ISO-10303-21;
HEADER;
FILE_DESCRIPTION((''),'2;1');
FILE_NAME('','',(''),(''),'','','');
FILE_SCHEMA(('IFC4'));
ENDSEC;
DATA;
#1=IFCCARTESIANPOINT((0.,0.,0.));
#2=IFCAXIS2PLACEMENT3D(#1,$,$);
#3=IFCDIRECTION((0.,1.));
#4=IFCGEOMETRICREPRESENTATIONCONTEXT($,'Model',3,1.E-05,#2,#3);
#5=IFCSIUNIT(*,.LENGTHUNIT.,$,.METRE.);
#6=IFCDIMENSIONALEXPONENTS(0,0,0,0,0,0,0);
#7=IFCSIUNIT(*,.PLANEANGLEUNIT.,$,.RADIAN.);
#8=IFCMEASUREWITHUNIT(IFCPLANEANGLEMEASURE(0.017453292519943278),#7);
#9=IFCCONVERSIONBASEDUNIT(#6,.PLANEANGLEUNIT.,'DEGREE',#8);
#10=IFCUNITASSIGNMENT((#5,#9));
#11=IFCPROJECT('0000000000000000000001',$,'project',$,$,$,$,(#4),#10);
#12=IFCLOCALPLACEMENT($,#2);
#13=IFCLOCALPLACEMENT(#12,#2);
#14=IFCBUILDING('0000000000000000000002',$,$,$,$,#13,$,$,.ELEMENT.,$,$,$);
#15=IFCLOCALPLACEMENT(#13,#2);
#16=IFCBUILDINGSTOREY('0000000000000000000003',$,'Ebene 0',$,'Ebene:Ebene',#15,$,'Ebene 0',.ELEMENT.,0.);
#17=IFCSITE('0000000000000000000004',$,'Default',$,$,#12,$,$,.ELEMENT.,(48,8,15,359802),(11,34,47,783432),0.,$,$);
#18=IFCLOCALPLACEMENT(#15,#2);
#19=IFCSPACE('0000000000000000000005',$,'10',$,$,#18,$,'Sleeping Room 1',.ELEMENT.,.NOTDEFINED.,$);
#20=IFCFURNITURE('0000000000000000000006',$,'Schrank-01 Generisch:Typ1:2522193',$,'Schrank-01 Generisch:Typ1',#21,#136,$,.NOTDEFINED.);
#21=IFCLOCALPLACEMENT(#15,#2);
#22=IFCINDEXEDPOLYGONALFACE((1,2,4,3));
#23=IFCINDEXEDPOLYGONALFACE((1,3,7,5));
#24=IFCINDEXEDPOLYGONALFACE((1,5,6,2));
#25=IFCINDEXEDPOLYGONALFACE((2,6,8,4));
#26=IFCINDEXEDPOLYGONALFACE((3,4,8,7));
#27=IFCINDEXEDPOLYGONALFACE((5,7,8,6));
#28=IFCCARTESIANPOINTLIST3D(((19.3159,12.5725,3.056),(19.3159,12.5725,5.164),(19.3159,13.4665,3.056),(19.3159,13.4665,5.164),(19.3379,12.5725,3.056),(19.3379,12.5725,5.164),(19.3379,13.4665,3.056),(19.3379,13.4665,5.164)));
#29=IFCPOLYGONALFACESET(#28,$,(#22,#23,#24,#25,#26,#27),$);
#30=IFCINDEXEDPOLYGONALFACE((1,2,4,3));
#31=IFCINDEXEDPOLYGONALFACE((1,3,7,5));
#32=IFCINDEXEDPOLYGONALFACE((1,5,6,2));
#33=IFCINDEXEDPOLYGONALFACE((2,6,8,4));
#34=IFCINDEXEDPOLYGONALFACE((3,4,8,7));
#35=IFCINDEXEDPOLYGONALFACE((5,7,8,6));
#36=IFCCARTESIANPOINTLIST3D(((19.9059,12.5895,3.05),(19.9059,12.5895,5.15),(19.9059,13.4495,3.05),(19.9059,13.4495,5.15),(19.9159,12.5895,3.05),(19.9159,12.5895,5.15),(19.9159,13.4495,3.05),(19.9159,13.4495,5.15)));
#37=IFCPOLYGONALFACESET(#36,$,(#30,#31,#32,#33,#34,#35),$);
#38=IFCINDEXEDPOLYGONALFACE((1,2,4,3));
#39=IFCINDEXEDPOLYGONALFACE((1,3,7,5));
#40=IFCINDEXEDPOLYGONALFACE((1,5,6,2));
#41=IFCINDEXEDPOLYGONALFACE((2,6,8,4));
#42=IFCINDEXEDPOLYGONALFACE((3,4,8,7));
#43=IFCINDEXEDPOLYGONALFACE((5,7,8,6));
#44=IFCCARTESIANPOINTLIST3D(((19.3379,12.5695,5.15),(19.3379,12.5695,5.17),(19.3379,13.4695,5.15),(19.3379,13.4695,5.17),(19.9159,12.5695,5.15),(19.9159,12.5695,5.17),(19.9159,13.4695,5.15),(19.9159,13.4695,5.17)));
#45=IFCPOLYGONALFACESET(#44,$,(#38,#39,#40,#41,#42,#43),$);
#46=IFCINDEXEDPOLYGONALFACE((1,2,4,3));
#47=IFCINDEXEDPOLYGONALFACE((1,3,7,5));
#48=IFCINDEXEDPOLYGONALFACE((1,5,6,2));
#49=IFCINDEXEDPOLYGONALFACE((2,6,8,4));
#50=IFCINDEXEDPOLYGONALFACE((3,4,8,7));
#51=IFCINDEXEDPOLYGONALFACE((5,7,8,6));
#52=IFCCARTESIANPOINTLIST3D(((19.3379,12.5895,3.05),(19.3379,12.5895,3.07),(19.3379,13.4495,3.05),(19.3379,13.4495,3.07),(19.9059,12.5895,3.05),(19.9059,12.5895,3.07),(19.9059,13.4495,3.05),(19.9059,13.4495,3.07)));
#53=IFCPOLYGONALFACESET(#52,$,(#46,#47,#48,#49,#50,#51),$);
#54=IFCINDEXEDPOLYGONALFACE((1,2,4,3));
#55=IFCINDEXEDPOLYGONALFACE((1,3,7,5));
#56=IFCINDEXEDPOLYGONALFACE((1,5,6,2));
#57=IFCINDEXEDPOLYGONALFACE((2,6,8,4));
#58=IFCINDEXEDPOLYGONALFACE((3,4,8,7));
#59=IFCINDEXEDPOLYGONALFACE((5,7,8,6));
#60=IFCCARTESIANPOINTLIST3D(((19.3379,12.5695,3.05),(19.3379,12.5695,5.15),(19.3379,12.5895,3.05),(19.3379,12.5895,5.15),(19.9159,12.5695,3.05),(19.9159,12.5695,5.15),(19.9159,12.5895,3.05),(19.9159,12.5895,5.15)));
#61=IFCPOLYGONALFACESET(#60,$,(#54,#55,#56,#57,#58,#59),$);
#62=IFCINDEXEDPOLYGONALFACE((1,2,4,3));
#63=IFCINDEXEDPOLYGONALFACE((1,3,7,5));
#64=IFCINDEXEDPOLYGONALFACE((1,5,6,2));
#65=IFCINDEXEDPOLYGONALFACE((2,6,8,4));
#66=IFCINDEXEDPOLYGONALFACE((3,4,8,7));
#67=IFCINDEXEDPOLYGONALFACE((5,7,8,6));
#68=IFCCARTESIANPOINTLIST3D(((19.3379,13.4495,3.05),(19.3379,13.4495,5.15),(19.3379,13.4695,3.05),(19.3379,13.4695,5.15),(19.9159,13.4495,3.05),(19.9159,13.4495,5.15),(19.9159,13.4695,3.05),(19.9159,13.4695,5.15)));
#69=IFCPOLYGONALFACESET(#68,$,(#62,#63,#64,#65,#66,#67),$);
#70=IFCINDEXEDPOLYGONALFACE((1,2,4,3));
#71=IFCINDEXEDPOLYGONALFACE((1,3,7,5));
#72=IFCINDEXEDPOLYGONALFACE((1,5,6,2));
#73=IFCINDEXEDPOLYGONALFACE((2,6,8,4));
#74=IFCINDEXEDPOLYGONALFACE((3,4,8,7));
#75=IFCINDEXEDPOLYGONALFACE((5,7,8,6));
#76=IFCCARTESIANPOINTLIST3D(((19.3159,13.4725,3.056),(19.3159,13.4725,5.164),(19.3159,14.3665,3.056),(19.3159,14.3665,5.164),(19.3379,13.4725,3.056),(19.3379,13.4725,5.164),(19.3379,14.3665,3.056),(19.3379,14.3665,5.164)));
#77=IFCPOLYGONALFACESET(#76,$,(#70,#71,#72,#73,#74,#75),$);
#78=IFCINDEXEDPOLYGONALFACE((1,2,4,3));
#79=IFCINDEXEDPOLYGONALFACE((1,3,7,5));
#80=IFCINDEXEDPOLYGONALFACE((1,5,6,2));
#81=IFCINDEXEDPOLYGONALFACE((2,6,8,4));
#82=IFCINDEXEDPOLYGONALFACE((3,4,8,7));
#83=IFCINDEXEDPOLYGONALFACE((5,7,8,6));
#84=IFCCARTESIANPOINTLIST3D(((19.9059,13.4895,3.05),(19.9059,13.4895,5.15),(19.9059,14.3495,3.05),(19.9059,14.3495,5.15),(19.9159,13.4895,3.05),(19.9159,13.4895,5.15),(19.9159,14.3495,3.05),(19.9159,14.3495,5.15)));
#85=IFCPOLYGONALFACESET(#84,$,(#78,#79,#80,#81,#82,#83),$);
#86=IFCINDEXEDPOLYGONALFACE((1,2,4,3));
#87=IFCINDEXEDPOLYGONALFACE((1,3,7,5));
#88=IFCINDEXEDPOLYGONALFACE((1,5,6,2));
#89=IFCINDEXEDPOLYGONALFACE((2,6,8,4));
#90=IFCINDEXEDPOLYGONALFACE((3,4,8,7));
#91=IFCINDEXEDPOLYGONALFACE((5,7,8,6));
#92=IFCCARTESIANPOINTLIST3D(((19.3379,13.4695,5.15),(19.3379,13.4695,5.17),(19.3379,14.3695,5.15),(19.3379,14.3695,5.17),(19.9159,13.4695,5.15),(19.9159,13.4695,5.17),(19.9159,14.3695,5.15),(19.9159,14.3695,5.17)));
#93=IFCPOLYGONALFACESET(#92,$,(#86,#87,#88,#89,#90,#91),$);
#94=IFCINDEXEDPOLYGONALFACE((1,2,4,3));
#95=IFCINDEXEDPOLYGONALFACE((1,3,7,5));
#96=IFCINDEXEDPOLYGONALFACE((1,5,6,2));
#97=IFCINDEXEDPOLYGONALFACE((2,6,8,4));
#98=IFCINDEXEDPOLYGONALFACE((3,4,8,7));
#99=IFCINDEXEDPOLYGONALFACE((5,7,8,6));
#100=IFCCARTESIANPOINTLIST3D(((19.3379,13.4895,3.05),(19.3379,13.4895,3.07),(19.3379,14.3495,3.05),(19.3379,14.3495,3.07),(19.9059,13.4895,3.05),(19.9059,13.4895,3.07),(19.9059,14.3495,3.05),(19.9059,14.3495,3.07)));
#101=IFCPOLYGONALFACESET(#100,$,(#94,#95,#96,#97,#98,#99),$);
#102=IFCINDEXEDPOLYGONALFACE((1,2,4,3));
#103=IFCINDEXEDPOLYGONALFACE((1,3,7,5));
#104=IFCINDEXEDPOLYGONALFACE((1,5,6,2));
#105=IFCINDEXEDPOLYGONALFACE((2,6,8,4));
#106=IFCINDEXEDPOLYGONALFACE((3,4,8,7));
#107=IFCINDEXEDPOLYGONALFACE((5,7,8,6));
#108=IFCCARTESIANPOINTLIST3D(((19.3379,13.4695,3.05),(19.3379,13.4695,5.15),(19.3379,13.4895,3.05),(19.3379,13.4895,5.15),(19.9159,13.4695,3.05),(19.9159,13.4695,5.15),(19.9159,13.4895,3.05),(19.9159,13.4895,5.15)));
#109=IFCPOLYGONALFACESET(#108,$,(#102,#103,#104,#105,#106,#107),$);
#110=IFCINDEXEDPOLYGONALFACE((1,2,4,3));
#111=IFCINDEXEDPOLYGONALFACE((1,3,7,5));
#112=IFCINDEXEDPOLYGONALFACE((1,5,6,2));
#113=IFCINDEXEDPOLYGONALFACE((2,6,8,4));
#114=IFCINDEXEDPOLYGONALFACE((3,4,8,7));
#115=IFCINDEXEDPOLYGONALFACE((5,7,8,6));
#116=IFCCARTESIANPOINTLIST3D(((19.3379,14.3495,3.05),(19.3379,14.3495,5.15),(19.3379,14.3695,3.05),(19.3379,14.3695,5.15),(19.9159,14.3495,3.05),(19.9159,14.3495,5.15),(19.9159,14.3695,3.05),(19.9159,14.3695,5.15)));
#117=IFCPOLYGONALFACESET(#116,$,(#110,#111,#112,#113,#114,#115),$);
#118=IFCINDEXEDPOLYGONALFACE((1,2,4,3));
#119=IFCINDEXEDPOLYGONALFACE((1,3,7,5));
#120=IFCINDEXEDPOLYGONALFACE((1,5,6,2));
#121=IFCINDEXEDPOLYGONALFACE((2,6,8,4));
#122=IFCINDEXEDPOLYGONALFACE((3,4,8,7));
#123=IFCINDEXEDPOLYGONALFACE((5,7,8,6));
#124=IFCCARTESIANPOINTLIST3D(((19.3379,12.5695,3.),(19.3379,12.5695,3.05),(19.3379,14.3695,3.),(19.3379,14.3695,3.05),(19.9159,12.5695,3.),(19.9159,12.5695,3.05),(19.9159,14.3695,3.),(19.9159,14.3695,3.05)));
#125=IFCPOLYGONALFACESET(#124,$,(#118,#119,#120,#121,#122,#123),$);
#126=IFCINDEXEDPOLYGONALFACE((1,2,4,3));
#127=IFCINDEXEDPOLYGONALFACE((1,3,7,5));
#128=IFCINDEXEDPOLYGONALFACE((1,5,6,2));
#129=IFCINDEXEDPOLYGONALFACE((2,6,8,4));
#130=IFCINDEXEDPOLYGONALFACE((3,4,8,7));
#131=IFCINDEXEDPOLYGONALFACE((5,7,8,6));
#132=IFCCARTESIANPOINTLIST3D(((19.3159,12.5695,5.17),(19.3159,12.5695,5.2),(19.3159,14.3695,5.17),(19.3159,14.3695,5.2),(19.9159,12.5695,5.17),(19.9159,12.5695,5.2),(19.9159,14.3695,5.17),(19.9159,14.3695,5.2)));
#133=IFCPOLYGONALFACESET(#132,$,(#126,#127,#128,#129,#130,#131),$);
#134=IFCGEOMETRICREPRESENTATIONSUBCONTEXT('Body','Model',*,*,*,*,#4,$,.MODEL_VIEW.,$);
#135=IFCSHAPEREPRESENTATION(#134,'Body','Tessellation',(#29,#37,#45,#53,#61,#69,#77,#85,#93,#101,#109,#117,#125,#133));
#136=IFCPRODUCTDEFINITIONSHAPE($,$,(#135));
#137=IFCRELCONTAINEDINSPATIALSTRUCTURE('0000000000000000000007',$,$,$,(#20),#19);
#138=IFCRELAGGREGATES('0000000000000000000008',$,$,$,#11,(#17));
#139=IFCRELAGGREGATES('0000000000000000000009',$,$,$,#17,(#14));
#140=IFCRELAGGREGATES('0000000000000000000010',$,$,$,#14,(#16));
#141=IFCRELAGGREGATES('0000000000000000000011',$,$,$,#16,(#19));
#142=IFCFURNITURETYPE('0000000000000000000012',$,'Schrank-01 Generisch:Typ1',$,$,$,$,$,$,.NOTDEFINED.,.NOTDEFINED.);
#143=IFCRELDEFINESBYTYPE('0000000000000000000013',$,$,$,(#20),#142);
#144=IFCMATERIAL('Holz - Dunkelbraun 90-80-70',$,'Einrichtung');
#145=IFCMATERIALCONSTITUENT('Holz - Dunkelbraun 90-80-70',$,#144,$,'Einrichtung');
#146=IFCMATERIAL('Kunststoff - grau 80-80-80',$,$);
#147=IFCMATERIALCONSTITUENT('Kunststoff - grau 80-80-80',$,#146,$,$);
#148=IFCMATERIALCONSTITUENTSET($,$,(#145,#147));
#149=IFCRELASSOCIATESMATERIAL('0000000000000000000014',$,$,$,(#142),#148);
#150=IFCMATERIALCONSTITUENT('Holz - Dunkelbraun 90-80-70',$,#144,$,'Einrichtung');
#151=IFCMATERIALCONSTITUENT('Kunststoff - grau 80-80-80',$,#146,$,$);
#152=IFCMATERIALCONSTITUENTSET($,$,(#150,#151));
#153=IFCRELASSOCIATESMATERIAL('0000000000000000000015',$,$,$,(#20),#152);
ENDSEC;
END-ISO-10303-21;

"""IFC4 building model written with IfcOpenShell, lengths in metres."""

from ifc_helpers import new_model, entity, si_unit, converted_unit, direction, frame, origin, place, context, subcontext, project, spatial, indexed_curve, outline, extrude, source, transform, mapped, material, constituent, constituent_set, type_object, type_shapes, element, save


model = new_model("IFC4")

# Units and contexts
model_context = context("Model", 3, precision=1e-05, world=origin(), true_north=direction((0.0, 1.0)))
body_context = subcontext(model_context, "Body", "Model", "MODEL_VIEW")
ifc_project = project(units=[si_unit("LENGTHUNIT", "METRE"), converted_unit("PLANEANGLEUNIT", "DEGREE", entity("IfcPlaneAngleMeasure", 0.017453292519943278), si_unit("PLANEANGLEUNIT", "RADIAN"), dimensions=[0, 0, 0, 0, 0, 0, 0])], contexts=[model_context])

# Site, building, storey
site_placement = place(None, origin())
site = spatial("IfcSite", under=ifc_project, at=site_placement, Name="Default", CompositionType="ELEMENT", RefLatitude=(48, 8, 15, 359802), RefLongitude=(11, 34, 47, 783432), RefElevation=0.0)
building_placement = place(site_placement, origin())
building = spatial("IfcBuilding", under=site, at=building_placement, CompositionType="ELEMENT")
storey_placement = place(building_placement, origin())
storey = spatial("IfcBuildingStorey", under=building, at=storey_placement, Name="Ebene 0", ObjectType="Ebene:Ebene", LongName="Ebene 0", CompositionType="ELEMENT", Elevation=0.0)

# Shared definitions
ifc_material_1 = material(Name="Holz - Dunkelbraun 90-80-70", Category="Einrichtung")
ifc_material_2 = material(Name="Kunststoff - grau 80-80-80")

# Shared definitions
space_1_placement = place(storey_placement, origin())
space_1 = spatial("IfcSpace", under=storey, at=space_1_placement, Name="10", LongName="Sleeping Room 1", CompositionType="ELEMENT", PredefinedType="NOTDEFINED")

# Furniture
ifc_constituent_1 = constituent(ifc_material_1, Name="Holz - Dunkelbraun 90-80-70", Category="Einrichtung")
ifc_constituent_2 = constituent(ifc_material_2, Name="Kunststoff - grau 80-80-80")
ifc_constituent_set_1 = constituent_set(constituents=[ifc_constituent_1, ifc_constituent_2])
ifc_constituent_3 = constituent(ifc_material_1, Name="Holz - Dunkelbraun 90-80-70", Category="Einrichtung")
ifc_constituent_4 = constituent(ifc_material_2, Name="Kunststoff - grau 80-80-80")
ifc_constituent_set_2 = constituent_set(constituents=[ifc_constituent_3, ifc_constituent_4])
furniture_type_1 = type_object("IfcFurnitureType", Name="Schrank-01 Generisch:Typ1", AssemblyPlace="NOTDEFINED", PredefinedType="NOTDEFINED", material=ifc_constituent_set_2)
shared_shape_1 = source(origin(), body_context, "Body", "SweptSolid", [
    extrude(outline(indexed_curve([(-0.447, -0.011), (0.447, -0.011), (0.447, 0.011), (-0.447, 0.011), (-0.447, -0.011)], self_intersect=False)), frame((0.45, -0.289, 0.056), z_axis=(0.0, 0.0, 1.0), x_axis=(-1.0, 0.0, 0.0)), (0.0, 0.0, 1.0), 2.108),
    extrude(outline(indexed_curve([(-0.43, -0.005), (0.43, -0.005), (0.43, 0.005), (-0.43, 0.005), (-0.43, -0.005)], self_intersect=False)), frame((0.45, 0.295, 0.05), z_axis=(0.0, 0.0, 1.0), x_axis=(-1.0, 0.0, 0.0)), (0.0, 0.0, 1.0), 2.1),
    extrude(outline(indexed_curve([(-0.45, -0.289), (0.45, -0.289), (0.45, 0.289), (-0.45, 0.289), (-0.45, -0.289)], self_intersect=False)), frame((0.45, 0.011, 2.15), z_axis=(0.0, 0.0, 1.0), x_axis=(-1.0, 0.0, 0.0)), (0.0, 0.0, 1.0), 0.02),
    extrude(outline(indexed_curve([(-0.43, -0.284), (0.43, -0.284), (0.43, 0.284), (-0.43, 0.284), (-0.43, -0.284)], self_intersect=False)), frame((0.45, 0.006, 0.05), z_axis=(0.0, 0.0, 1.0), x_axis=(-1.0, 0.0, 0.0)), (0.0, 0.0, 1.0), 0.02),
    extrude(outline(indexed_curve([(-0.01, -0.289), (0.01, -0.289), (0.01, 0.289), (-0.01, 0.289), (-0.01, -0.289)], self_intersect=False)), frame((0.89, 0.011, 0.05), z_axis=(0.0, 0.0, 1.0), x_axis=(-1.0, 0.0, 0.0)), (0.0, 0.0, 1.0), 2.1),
    extrude(outline(indexed_curve([(-0.01, -0.289), (0.01, -0.289), (0.01, 0.289), (-0.01, 0.289), (-0.01, -0.289)], self_intersect=False)), frame((0.01, 0.011, 0.05), z_axis=(0.0, 0.0, 1.0), x_axis=(-1.0, 0.0, 0.0)), (0.0, 0.0, 1.0), 2.1),
    extrude(outline(indexed_curve([(-0.447, -0.011), (0.447, -0.011), (0.447, 0.011), (-0.447, 0.011), (-0.447, -0.011)], self_intersect=False)), frame((-0.45, -0.289, 0.056), z_axis=(0.0, 0.0, 1.0), x_axis=(-1.0, 0.0, 0.0)), (0.0, 0.0, 1.0), 2.108),
    extrude(outline(indexed_curve([(-0.43, -0.005), (0.43, -0.005), (0.43, 0.005), (-0.43, 0.005), (-0.43, -0.005)], self_intersect=False)), frame((-0.45, 0.295, 0.05), z_axis=(0.0, 0.0, 1.0), x_axis=(-1.0, 0.0, 0.0)), (0.0, 0.0, 1.0), 2.1),
    extrude(outline(indexed_curve([(-0.45, -0.289), (0.45, -0.289), (0.45, 0.289), (-0.45, 0.289), (-0.45, -0.289)], self_intersect=False)), frame((-0.45, 0.011, 2.15), z_axis=(0.0, 0.0, 1.0), x_axis=(-1.0, 0.0, 0.0)), (0.0, 0.0, 1.0), 0.02),
    extrude(outline(indexed_curve([(-0.43, -0.284), (0.43, -0.284), (0.43, 0.284), (-0.43, 0.284), (-0.43, -0.284)], self_intersect=False)), frame((-0.45, 0.006, 0.05), z_axis=(0.0, 0.0, 1.0), x_axis=(-1.0, 0.0, 0.0)), (0.0, 0.0, 1.0), 0.02),
    extrude(outline(indexed_curve([(-0.01, -0.289), (0.01, -0.289), (0.01, 0.289), (-0.01, 0.289), (-0.01, -0.289)], self_intersect=False)), frame((-0.01, 0.011, 0.05), z_axis=(0.0, 0.0, 1.0), x_axis=(-1.0, 0.0, 0.0)), (0.0, 0.0, 1.0), 2.1),
    extrude(outline(indexed_curve([(-0.01, -0.289), (0.01, -0.289), (0.01, 0.289), (-0.01, 0.289), (-0.01, -0.289)], self_intersect=False)), frame((-0.89, 0.011, 0.05), z_axis=(0.0, 0.0, 1.0), x_axis=(-1.0, 0.0, 0.0)), (0.0, 0.0, 1.0), 2.1),
    extrude(outline(indexed_curve([(-0.9, -0.289), (0.9, -0.289), (0.9, 0.289), (-0.9, 0.289), (-0.9, -0.289)], self_intersect=False)), frame((0.0, 0.011, 0.0), z_axis=(0.0, 0.0, 1.0), x_axis=(-1.0, 0.0, 0.0)), (0.0, 0.0, 1.0), 0.05),
    extrude(outline(indexed_curve([(-0.9, -0.3), (0.9, -0.3), (0.9, 0.3), (-0.9, 0.3), (-0.9, -0.3)], self_intersect=False)), frame((0.0, 0.0, 2.17), z_axis=(0.0, 0.0, 1.0), x_axis=(-1.0, 0.0, 0.0)), (0.0, 0.0, 1.0), 0.03),
])
type_shapes(furniture_type_1, [shared_shape_1])
furniture_1_placement = place(space_1_placement, frame((19.6159, 13.4695, 3.0), z_axis=(0.0, 0.0, 1.0), x_axis=(0.0, -1.0, 0.0)))
element("IfcFurniture", 1, at=furniture_1_placement, inside=space_1, type_object=furniture_type_1, material=ifc_constituent_set_1, Name="Schrank-01 Generisch:Typ1:2522193", ObjectType="Schrank-01 Generisch:Typ1", PredefinedType="NOTDEFINED", context=body_context, shape_type="MappedRepresentation", body=[
    mapped(shared_shape_1, transform((0.0, 0.0, 0.0), scale=1.0)),
])

save(model, "model.ifc")
